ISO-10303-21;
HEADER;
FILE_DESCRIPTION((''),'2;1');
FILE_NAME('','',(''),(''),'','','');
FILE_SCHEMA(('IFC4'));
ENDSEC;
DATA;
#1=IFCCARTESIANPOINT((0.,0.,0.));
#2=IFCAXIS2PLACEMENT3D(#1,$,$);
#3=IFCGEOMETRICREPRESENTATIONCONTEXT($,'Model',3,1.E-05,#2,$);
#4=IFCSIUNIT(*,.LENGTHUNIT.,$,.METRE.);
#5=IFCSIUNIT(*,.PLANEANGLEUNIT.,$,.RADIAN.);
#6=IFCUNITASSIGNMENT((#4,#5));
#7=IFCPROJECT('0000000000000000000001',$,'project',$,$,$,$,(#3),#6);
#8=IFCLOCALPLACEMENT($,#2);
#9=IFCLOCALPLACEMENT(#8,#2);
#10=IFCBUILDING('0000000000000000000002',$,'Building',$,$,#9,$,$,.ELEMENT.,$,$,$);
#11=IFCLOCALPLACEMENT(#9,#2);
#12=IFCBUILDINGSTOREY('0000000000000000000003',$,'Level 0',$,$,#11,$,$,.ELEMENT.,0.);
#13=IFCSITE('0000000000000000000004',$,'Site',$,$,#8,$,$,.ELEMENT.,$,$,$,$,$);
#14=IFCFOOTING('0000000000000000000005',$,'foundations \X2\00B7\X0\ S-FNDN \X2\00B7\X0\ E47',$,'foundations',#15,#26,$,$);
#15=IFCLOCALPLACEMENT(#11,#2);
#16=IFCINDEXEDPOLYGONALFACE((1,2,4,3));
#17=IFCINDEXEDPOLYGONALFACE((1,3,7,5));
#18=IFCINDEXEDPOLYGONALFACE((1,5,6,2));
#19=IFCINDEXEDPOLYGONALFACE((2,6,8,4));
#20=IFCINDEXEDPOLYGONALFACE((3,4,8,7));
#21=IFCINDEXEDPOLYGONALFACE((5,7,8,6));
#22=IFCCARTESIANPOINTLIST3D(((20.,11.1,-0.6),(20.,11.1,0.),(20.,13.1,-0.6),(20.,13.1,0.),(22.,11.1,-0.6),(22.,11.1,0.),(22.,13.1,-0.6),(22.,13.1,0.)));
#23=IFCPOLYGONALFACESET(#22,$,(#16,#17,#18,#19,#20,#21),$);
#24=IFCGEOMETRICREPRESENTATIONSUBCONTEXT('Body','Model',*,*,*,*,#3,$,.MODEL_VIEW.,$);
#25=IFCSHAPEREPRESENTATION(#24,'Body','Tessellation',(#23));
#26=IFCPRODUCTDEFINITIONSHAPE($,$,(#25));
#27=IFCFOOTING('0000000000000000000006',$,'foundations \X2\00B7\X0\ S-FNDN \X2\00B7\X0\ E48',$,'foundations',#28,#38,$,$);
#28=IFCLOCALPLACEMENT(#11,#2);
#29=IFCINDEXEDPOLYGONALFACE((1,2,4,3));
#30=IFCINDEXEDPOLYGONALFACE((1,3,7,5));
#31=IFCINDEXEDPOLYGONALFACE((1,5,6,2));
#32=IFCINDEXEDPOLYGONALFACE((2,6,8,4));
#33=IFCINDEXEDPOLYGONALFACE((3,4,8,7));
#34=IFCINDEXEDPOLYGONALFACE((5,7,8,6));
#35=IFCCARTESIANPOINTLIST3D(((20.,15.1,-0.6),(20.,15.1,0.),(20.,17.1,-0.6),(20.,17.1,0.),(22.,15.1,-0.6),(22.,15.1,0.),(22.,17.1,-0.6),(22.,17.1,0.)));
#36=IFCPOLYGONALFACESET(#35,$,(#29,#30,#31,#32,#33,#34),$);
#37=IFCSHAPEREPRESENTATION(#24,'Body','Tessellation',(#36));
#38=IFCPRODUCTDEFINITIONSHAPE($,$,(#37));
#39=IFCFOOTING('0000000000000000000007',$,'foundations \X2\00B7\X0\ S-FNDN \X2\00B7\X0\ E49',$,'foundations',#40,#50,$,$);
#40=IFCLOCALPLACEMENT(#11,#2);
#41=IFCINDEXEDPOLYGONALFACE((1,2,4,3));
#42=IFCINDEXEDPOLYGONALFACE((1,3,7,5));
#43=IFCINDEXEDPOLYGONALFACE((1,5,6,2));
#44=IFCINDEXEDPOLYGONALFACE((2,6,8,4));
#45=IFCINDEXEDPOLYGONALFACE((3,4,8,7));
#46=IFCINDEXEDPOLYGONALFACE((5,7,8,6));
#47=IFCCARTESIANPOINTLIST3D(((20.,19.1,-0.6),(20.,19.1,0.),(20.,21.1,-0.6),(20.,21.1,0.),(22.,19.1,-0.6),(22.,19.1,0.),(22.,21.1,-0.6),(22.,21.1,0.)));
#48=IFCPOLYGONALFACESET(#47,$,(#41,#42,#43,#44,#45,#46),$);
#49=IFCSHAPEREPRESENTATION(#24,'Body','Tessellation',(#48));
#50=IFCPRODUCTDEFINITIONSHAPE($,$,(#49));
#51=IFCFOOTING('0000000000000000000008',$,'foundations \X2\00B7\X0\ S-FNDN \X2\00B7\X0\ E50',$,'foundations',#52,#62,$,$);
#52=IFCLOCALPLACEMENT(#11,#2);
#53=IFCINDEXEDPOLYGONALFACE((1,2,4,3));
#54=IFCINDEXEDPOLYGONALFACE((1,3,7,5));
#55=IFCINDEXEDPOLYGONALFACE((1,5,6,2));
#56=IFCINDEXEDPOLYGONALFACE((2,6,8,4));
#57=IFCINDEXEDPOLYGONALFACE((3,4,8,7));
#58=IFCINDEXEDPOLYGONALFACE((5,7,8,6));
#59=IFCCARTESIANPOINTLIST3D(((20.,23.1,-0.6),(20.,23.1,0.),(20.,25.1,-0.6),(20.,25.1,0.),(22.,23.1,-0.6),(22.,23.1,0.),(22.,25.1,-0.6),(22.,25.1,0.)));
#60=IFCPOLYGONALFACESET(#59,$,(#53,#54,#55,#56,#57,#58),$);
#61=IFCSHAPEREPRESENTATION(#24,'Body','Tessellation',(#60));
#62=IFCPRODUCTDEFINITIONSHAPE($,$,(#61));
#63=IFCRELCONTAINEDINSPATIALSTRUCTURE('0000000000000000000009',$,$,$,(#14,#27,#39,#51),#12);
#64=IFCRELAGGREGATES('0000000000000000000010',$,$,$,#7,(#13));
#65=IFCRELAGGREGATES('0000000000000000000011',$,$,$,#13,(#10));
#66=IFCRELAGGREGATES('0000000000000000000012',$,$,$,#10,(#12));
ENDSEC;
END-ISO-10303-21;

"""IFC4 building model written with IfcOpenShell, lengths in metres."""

from ifc_helpers import new_model, si_unit, frame, origin, place, context, subcontext, project, spatial, polyline, outline, extrude, element, save


model = new_model("IFC4")

# Units and contexts
model_context = context("Model", 3, precision=1e-05, world=origin())
body_context = subcontext(model_context, "Body", "Model", "MODEL_VIEW")
ifc_project = project(units=[si_unit("LENGTHUNIT", "METRE"), si_unit("PLANEANGLEUNIT", "RADIAN")], contexts=[model_context])

# Site, building, storey
site_placement = place(None, origin())
site = spatial("IfcSite", under=ifc_project, at=site_placement, Name="Site", CompositionType="ELEMENT")
building_placement = place(site_placement, origin())
building = spatial("IfcBuilding", under=site, at=building_placement, Name="Building", CompositionType="ELEMENT")
storey_placement = place(building_placement, origin())
storey = spatial("IfcBuildingStorey", under=building, at=storey_placement, Name="Level 0", CompositionType="ELEMENT", Elevation=0.0)

# Footings
footing_1_placement = place(storey_placement, frame((0.0, 0.0, -0.6)))
element("IfcFooting", 1, at=footing_1_placement, inside=storey, Name="foundations · S-FNDN · E47", ObjectType="foundations", context=body_context, shape_type="SweptSolid", body=[
    extrude(outline(polyline([(20.0, 11.1), (22.0, 11.1), (22.0, 13.1), (20.0, 13.1), (20.0, 11.1)])), origin(), (0.0, 0.0, 1.0), 0.6),
])
footing_2_placement = place(storey_placement, frame((0.0, 0.0, -0.6)))
element("IfcFooting", 2, at=footing_2_placement, inside=storey, Name="foundations · S-FNDN · E48", ObjectType="foundations", context=body_context, shape_type="SweptSolid", body=[
    extrude(outline(polyline([(20.0, 15.1), (22.0, 15.1), (22.0, 17.1), (20.0, 17.1), (20.0, 15.1)])), origin(), (0.0, 0.0, 1.0), 0.6),
])
footing_3_placement = place(storey_placement, frame((0.0, 0.0, -0.6)))
element("IfcFooting", 3, at=footing_3_placement, inside=storey, Name="foundations · S-FNDN · E49", ObjectType="foundations", context=body_context, shape_type="SweptSolid", body=[
    extrude(outline(polyline([(20.0, 19.1), (22.0, 19.1), (22.0, 21.1), (20.0, 21.1), (20.0, 19.1)])), origin(), (0.0, 0.0, 1.0), 0.6),
])
footing_4_placement = place(storey_placement, frame((0.0, 0.0, -0.6)))
element("IfcFooting", 4, at=footing_4_placement, inside=storey, Name="foundations · S-FNDN · E50", ObjectType="foundations", context=body_context, shape_type="SweptSolid", body=[
    extrude(outline(polyline([(20.0, 23.1), (22.0, 23.1), (22.0, 25.1), (20.0, 25.1), (20.0, 23.1)])), origin(), (0.0, 0.0, 1.0), 0.6),
])

save(model, "model.ifc")
